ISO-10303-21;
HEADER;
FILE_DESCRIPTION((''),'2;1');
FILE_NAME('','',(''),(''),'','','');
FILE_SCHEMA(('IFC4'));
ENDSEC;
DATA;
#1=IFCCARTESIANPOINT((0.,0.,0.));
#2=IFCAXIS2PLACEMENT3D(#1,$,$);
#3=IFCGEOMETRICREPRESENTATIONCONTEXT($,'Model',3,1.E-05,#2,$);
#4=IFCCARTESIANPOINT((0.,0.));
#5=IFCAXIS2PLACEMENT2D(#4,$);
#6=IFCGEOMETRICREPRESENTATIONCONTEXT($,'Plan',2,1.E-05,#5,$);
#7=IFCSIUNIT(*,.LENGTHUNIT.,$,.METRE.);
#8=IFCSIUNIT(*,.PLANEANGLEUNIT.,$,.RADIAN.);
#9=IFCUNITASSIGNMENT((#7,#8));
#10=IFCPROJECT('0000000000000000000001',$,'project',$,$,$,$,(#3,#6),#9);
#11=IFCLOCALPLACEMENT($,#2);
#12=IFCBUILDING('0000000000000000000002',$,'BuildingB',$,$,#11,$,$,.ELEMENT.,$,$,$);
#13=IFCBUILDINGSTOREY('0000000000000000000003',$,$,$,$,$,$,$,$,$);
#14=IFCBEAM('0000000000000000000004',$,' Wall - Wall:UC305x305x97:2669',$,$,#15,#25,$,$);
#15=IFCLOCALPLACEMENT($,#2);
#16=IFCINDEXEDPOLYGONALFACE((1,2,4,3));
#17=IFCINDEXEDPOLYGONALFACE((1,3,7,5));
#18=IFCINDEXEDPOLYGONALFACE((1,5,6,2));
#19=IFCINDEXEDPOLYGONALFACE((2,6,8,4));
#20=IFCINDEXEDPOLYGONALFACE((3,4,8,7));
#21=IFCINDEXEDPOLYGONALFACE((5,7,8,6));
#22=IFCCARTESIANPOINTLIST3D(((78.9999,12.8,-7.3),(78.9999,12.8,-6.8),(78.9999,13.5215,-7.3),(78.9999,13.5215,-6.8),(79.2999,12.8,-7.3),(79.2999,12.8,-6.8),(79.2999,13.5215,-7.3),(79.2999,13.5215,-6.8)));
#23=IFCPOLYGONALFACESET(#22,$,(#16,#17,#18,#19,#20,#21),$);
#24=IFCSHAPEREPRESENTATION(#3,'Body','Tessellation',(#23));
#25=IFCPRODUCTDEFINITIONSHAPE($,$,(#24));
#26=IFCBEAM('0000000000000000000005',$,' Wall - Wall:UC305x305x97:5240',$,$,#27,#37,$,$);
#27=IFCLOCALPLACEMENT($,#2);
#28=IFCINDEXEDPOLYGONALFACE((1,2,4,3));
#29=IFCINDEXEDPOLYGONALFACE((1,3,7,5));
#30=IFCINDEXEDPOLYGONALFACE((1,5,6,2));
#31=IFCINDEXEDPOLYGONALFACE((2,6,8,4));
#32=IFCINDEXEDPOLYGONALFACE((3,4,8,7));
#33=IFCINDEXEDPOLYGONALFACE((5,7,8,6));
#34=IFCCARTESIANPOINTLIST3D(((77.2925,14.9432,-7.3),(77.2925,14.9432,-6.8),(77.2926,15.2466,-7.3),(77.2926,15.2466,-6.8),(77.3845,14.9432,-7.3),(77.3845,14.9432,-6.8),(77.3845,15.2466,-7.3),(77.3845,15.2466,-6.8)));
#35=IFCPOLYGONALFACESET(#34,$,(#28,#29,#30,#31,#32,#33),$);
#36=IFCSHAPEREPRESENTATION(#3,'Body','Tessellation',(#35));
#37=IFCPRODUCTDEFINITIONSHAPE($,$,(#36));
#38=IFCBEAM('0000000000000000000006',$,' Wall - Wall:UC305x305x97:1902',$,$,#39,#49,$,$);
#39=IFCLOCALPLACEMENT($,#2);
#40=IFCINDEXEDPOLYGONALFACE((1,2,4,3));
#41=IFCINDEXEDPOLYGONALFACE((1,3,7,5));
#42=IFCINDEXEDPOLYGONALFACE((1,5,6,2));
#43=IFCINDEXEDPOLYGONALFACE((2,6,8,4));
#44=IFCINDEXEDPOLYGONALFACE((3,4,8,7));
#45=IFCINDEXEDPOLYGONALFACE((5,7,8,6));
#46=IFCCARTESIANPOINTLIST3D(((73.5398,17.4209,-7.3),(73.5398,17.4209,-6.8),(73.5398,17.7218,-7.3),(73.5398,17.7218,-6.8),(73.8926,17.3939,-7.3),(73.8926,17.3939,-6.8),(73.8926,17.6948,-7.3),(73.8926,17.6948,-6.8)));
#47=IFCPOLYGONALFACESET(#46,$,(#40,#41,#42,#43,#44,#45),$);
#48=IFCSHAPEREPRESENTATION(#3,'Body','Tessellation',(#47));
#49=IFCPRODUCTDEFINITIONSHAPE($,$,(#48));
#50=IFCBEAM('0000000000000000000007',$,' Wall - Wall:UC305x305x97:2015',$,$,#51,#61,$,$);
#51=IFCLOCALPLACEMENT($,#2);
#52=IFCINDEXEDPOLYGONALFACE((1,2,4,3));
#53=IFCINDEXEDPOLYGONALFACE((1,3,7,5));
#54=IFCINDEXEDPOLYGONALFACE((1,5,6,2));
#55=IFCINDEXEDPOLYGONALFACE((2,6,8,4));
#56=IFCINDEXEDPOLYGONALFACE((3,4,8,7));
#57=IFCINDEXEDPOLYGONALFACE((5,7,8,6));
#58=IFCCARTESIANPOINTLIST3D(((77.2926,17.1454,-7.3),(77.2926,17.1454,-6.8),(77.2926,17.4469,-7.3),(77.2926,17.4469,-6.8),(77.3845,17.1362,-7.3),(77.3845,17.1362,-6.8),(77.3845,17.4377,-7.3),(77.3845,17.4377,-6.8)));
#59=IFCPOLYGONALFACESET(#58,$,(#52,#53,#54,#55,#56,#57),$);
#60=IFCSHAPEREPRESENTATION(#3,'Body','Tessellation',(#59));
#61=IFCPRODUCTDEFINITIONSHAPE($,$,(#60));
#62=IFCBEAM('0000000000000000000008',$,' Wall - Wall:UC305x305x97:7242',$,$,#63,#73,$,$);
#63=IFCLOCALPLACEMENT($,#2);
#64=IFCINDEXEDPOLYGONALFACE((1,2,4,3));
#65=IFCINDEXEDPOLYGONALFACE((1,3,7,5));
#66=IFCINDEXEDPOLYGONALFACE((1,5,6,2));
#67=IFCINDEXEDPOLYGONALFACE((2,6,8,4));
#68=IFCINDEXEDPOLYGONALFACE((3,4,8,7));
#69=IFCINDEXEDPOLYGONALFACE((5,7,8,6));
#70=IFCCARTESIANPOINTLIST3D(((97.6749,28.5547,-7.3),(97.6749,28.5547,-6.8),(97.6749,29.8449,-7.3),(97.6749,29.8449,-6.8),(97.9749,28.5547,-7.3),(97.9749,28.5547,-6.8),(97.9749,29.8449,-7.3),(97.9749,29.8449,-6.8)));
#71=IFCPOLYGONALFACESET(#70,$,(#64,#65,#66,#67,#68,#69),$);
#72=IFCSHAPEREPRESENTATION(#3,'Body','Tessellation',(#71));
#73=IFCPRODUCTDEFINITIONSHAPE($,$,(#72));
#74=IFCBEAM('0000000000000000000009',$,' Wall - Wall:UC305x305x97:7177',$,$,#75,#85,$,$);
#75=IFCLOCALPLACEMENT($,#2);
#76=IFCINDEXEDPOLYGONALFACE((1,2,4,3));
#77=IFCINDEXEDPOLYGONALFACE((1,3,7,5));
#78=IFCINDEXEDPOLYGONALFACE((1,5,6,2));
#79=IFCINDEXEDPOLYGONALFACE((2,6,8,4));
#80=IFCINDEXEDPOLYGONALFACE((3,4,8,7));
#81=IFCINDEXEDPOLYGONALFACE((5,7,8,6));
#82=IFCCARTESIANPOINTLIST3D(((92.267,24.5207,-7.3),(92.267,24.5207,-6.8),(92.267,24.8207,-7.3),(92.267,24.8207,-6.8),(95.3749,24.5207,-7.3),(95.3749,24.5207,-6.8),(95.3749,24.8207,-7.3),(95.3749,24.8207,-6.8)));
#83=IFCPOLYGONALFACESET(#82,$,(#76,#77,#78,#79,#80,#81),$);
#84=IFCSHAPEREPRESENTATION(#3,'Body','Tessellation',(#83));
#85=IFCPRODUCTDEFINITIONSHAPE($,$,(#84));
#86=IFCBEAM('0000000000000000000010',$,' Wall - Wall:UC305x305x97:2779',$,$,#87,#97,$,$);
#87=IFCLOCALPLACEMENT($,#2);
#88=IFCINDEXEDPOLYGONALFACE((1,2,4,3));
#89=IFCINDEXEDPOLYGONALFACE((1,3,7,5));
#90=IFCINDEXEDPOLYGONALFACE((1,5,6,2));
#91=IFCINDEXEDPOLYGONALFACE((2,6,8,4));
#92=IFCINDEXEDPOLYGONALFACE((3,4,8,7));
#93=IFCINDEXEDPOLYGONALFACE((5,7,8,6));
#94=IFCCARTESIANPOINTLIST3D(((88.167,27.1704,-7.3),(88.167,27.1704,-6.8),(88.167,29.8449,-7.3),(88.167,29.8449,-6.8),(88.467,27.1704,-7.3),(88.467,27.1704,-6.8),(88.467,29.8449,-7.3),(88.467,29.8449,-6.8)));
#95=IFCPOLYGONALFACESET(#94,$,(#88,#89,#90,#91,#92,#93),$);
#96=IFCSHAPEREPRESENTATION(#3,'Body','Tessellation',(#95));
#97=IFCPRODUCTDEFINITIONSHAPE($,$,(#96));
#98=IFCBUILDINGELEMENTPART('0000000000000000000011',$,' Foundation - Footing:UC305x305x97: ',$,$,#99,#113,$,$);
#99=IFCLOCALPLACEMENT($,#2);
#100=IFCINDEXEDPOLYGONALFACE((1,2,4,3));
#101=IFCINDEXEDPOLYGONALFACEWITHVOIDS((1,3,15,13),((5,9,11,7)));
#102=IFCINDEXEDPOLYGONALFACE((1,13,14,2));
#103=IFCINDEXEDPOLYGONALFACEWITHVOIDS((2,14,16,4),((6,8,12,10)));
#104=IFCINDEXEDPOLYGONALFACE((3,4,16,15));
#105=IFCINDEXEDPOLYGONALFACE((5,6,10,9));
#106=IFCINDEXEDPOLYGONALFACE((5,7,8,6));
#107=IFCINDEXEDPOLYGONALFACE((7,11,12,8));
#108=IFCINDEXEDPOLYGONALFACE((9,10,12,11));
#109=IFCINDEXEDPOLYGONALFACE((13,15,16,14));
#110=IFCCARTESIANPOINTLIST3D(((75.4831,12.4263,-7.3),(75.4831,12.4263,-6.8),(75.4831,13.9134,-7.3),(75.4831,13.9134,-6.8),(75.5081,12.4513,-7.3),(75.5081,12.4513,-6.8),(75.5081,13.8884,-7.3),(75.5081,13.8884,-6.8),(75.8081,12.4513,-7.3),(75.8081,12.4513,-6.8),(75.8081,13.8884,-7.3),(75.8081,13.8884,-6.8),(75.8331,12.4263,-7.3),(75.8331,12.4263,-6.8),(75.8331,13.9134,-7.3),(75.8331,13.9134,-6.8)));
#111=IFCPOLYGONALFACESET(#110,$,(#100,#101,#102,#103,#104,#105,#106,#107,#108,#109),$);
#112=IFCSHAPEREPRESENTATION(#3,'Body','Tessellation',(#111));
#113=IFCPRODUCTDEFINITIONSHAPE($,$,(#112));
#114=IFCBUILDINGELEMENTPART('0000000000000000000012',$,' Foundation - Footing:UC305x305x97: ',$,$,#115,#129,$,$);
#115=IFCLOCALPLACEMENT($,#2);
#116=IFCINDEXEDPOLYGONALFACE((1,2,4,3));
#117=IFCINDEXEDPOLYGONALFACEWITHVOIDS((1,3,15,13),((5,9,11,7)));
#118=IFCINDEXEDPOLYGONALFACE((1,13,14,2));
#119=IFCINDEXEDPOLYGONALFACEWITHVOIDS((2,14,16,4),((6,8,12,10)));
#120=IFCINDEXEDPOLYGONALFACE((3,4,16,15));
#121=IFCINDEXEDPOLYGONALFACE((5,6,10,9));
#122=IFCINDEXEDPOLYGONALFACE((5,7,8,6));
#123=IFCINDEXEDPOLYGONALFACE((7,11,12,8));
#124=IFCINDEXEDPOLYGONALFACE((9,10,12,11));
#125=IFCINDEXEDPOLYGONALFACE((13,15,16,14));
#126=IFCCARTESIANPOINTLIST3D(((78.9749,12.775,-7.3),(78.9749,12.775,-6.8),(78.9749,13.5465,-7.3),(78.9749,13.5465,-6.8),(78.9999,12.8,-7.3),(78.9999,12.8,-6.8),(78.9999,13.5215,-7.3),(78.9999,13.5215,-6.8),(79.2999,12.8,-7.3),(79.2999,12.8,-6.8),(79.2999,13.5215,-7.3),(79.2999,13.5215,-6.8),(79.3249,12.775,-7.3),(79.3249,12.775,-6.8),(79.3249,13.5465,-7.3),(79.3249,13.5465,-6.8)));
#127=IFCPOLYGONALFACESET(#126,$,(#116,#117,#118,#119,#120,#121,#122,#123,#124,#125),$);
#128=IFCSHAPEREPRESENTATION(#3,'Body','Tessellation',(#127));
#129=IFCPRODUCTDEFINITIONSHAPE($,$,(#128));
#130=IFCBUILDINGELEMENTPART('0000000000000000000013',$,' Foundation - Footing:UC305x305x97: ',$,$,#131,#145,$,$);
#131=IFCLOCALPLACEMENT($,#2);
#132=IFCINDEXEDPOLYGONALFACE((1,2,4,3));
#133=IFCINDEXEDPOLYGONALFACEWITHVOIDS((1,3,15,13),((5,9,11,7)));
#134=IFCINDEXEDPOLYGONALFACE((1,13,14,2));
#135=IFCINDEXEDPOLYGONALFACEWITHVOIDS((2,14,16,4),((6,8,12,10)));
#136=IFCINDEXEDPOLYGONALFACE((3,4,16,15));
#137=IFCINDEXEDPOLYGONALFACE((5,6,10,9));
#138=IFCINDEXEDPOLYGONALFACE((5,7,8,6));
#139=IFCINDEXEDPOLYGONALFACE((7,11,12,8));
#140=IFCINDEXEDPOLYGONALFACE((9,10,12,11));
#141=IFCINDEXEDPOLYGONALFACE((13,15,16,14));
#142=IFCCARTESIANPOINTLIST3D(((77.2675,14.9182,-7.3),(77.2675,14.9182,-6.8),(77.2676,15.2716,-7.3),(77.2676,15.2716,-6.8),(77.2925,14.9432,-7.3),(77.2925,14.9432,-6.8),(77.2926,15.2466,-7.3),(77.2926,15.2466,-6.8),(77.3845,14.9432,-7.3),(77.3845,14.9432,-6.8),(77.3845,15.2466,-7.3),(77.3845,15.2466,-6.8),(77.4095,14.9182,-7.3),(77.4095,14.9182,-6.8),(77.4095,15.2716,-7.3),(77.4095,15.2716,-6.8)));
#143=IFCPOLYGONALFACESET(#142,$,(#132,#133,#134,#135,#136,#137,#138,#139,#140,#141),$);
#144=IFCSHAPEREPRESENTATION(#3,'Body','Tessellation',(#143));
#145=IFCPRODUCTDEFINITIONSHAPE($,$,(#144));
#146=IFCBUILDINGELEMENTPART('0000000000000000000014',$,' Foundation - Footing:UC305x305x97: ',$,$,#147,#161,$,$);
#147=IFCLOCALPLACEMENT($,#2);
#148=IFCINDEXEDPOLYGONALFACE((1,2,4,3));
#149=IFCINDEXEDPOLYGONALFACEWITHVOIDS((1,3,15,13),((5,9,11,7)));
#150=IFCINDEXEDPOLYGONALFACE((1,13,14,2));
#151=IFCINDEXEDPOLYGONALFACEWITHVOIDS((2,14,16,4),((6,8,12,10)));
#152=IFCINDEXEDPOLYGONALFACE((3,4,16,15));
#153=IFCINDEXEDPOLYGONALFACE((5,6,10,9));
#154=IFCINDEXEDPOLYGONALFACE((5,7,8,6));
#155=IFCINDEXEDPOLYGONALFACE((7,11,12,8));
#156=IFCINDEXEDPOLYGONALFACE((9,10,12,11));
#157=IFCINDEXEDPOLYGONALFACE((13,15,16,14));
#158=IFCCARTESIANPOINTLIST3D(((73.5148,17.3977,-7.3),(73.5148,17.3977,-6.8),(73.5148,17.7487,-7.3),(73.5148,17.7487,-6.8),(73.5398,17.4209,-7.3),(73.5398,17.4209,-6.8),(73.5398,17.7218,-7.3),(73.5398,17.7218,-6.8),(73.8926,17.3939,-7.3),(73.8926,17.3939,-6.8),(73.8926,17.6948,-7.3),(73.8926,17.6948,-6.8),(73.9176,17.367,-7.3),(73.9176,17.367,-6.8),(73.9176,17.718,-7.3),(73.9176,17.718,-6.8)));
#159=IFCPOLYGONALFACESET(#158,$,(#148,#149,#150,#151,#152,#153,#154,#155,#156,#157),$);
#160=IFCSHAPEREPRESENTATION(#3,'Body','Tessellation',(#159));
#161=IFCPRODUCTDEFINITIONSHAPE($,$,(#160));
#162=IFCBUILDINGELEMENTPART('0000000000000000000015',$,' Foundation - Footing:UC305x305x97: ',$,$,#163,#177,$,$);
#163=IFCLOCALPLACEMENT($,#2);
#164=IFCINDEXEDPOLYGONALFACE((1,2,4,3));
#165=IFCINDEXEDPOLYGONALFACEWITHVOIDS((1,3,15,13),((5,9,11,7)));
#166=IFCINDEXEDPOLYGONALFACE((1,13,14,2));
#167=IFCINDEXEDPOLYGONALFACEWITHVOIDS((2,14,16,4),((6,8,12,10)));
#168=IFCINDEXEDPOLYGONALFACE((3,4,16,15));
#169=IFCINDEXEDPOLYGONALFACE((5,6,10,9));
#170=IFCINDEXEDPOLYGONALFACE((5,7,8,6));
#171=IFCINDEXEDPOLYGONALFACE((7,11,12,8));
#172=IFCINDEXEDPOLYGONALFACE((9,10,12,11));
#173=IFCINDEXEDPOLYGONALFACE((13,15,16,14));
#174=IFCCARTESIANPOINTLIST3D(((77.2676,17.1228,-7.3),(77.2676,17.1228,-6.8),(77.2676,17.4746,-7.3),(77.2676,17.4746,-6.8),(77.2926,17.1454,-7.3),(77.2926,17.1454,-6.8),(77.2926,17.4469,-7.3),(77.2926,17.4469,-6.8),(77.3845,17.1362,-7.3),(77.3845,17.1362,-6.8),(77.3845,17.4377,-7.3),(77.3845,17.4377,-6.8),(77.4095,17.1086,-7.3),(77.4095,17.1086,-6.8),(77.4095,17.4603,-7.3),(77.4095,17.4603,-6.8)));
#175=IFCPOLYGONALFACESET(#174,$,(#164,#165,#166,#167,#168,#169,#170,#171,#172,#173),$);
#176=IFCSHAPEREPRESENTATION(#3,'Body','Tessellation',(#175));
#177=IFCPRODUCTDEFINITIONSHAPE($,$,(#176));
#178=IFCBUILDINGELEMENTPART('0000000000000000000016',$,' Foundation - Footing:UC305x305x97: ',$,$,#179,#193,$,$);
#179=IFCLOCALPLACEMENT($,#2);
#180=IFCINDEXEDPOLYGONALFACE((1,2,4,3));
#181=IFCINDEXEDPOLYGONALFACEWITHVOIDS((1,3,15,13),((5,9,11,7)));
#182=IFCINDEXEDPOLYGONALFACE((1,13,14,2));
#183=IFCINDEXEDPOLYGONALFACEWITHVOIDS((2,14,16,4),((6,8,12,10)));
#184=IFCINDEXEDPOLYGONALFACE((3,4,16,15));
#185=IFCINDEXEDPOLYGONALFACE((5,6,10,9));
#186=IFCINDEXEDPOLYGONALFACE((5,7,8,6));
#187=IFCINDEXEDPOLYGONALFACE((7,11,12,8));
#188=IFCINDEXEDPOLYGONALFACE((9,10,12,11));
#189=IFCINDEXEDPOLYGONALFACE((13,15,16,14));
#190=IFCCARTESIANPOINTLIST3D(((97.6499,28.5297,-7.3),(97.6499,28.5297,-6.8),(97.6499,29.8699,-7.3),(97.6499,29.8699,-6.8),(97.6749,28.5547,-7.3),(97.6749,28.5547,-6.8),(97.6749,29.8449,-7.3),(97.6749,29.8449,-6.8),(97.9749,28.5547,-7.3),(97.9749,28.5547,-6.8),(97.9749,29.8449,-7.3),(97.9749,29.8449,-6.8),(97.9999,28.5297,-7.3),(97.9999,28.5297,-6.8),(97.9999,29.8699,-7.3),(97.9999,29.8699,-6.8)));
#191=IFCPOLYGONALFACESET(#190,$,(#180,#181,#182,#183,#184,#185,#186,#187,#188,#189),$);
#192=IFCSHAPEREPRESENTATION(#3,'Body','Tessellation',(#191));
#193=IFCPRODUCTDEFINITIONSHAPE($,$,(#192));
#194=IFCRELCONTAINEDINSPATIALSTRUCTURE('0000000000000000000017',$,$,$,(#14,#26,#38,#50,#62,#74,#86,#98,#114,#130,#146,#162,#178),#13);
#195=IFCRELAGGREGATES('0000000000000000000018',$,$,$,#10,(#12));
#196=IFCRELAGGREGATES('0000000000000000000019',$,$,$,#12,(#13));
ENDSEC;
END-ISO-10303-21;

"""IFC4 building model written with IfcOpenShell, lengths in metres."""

from ifc_helpers import new_model, si_unit, origin, origin_2d, place, context, project, spatial, polyline, outline, extrude, element, save


model = new_model("IFC4")

# Units and contexts
model_context = context("Model", 3, precision=1e-05, world=origin())
plan_context = context("Plan", 2, precision=1e-05, world=origin_2d())
ifc_project = project(units=[si_unit("LENGTHUNIT", "METRE"), si_unit("PLANEANGLEUNIT", "RADIAN")], contexts=[model_context, plan_context])

# Building, storey
building_placement = place(None, origin())
building = spatial("IfcBuilding", under=ifc_project, at=building_placement, Name="BuildingB", CompositionType="ELEMENT")
storey = spatial("IfcBuildingStorey", under=building)

# Beams
element("IfcBeam", 1, inside=storey, Name=" Wall - Wall:UC305x305x97:2669", context=model_context, shape_type="SweptSolid", body=[
    extrude(outline(polyline([(79.2999, 12.8, -7.3), (78.9999, 12.8, -7.3), (78.9999, 13.5215, -7.3), (79.2999, 13.5215, -7.3), (79.2999, 12.8, -7.3)])), None, (0.0, 0.0, 1.0), 0.5),
])
element("IfcBeam", 2, inside=storey, Name=" Wall - Wall:UC305x305x97:5240", context=model_context, shape_type="SweptSolid", body=[
    extrude(outline(polyline([(77.3845, 14.9432, -7.3), (77.2925, 14.9432, -7.3), (77.2926, 15.2466, -7.3), (77.3845, 15.2466, -7.3), (77.3845, 14.9432, -7.3)])), None, (0.0, 0.0, 1.0), 0.5),
])
element("IfcBeam", 3, inside=storey, Name=" Wall - Wall:UC305x305x97:1902", context=model_context, shape_type="SweptSolid", body=[
    extrude(outline(polyline([(73.8926, 17.3939, -7.3), (73.5398, 17.4209, -7.3), (73.5398, 17.7218, -7.3), (73.8926, 17.6948, -7.3), (73.8926, 17.3939, -7.3)])), None, (0.0, 0.0, 1.0), 0.5),
])
element("IfcBeam", 4, inside=storey, Name=" Wall - Wall:UC305x305x97:2015", context=model_context, shape_type="SweptSolid", body=[
    extrude(outline(polyline([(77.3845, 17.1362, -7.3), (77.2926, 17.1454, -7.3), (77.2926, 17.4469, -7.3), (77.3845, 17.4377, -7.3), (77.3845, 17.1362, -7.3)])), None, (0.0, 0.0, 1.0), 0.5),
])
element("IfcBeam", 5, inside=storey, Name=" Wall - Wall:UC305x305x97:7242", context=model_context, shape_type="SweptSolid", body=[
    extrude(outline(polyline([(97.9749, 28.5547, -7.3), (97.6749, 28.5547, -7.3), (97.6749, 29.8449, -7.3), (97.9749, 29.8449, -7.3), (97.9749, 28.5547, -7.3)])), None, (0.0, 0.0, 1.0), 0.5),
])
element("IfcBeam", 6, inside=storey, Name=" Wall - Wall:UC305x305x97:7177", context=model_context, shape_type="SweptSolid", body=[
    extrude(outline(polyline([(95.3749, 24.5207, -7.3), (95.3749, 24.8207, -7.3), (92.267, 24.8207, -7.3), (92.267, 24.5207, -7.3), (95.3749, 24.5207, -7.3)])), None, (0.0, 0.0, 1.0), 0.5),
])
element("IfcBeam", 7, inside=storey, Name=" Wall - Wall:UC305x305x97:2779", context=model_context, shape_type="SweptSolid", body=[
    extrude(outline(polyline([(88.467, 27.1704, -7.3), (88.167, 27.1704, -7.3), (88.167, 29.8449, -7.3), (88.467, 29.8449, -7.3), (88.467, 27.1704, -7.3)])), None, (0.0, 0.0, 1.0), 0.5),
])

# Building element parts, openings
building_element_part_1 = element("IfcBuildingElementPart", 8, inside=storey, Name=" Foundation - Footing:UC305x305x97: ", context=model_context, shape_type="SweptSolid", body=[
    extrude(outline(polyline([(75.8331, 12.4263, -7.3), (75.4831, 12.4263, -7.3), (75.4831, 13.9134, -7.3), (75.8331, 13.9134, -7.3), (75.8331, 12.4263, -7.3)])), None, (0.0, 0.0, 1.0), 0.5),
])
element("IfcOpeningElement", 9, inside=storey, cuts=building_element_part_1, context=model_context, shape_type="SweptSolid", body=[
    extrude(outline(polyline([(75.8081, 12.4513, -7.3), (75.5081, 12.4513, -7.3), (75.5081, 13.8884, -7.3), (75.8081, 13.8884, -7.3), (75.8081, 12.4513, -7.3)])), None, (0.0, 0.0, 1.0), 0.5),
])
building_element_part_2 = element("IfcBuildingElementPart", 10, inside=storey, Name=" Foundation - Footing:UC305x305x97: ", context=model_context, shape_type="SweptSolid", body=[
    extrude(outline(polyline([(79.3249, 12.775, -7.3), (78.9749, 12.775, -7.3), (78.9749, 13.5465, -7.3), (79.3249, 13.5465, -7.3), (79.3249, 12.775, -7.3)])), None, (0.0, 0.0, 1.0), 0.5),
])
element("IfcOpeningElement", 11, inside=storey, cuts=building_element_part_2, context=model_context, shape_type="SweptSolid", body=[
    extrude(outline(polyline([(79.2999, 12.8, -7.3), (78.9999, 12.8, -7.3), (78.9999, 13.5215, -7.3), (79.2999, 13.5215, -7.3), (79.2999, 12.8, -7.3)])), None, (0.0, 0.0, 1.0), 0.5),
])
building_element_part_3 = element("IfcBuildingElementPart", 12, inside=storey, Name=" Foundation - Footing:UC305x305x97: ", context=model_context, shape_type="SweptSolid", body=[
    extrude(outline(polyline([(77.4095, 14.9182, -7.3), (77.2675, 14.9182, -7.3), (77.2676, 15.2716, -7.3), (77.4095, 15.2716, -7.3), (77.4095, 14.9182, -7.3)])), None, (0.0, 0.0, 1.0), 0.5),
])
element("IfcOpeningElement", 13, inside=storey, cuts=building_element_part_3, context=model_context, shape_type="SweptSolid", body=[
    extrude(outline(polyline([(77.3845, 14.9432, -7.3), (77.2925, 14.9432, -7.3), (77.2926, 15.2466, -7.3), (77.3845, 15.2466, -7.3), (77.3845, 14.9432, -7.3)])), None, (0.0, 0.0, 1.0), 0.5),
])
building_element_part_4 = element("IfcBuildingElementPart", 14, inside=storey, Name=" Foundation - Footing:UC305x305x97: ", context=model_context, shape_type="SweptSolid", body=[
    extrude(outline(polyline([(73.9176, 17.367, -7.3), (73.5148, 17.3977, -7.3), (73.5148, 17.7487, -7.3), (73.9176, 17.718, -7.3), (73.9176, 17.367, -7.3)])), None, (0.0, 0.0, 1.0), 0.5),
])
element("IfcOpeningElement", 15, inside=storey, cuts=building_element_part_4, context=model_context, shape_type="SweptSolid", body=[
    extrude(outline(polyline([(73.8926, 17.3939, -7.3), (73.5398, 17.4209, -7.3), (73.5398, 17.7218, -7.3), (73.8926, 17.6948, -7.3), (73.8926, 17.3939, -7.3)])), None, (0.0, 0.0, 1.0), 0.5),
])
building_element_part_5 = element("IfcBuildingElementPart", 16, inside=storey, Name=" Foundation - Footing:UC305x305x97: ", context=model_context, shape_type="SweptSolid", body=[
    extrude(outline(polyline([(77.4095, 17.1086, -7.3), (77.2676, 17.1228, -7.3), (77.2676, 17.4746, -7.3), (77.4095, 17.4603, -7.3), (77.4095, 17.1086, -7.3)])), None, (0.0, 0.0, 1.0), 0.5),
])
element("IfcOpeningElement", 17, inside=storey, cuts=building_element_part_5, context=model_context, shape_type="SweptSolid", body=[
    extrude(outline(polyline([(77.3845, 17.1362, -7.3), (77.2926, 17.1454, -7.3), (77.2926, 17.4469, -7.3), (77.3845, 17.4377, -7.3), (77.3845, 17.1362, -7.3)])), None, (0.0, 0.0, 1.0), 0.5),
])
building_element_part_6 = element("IfcBuildingElementPart", 18, inside=storey, Name=" Foundation - Footing:UC305x305x97: ", context=model_context, shape_type="SweptSolid", body=[
    extrude(outline(polyline([(97.9999, 28.5297, -7.3), (97.6499, 28.5297, -7.3), (97.6499, 29.8699, -7.3), (97.9999, 29.8699, -7.3), (97.9999, 28.5297, -7.3)])), None, (0.0, 0.0, 1.0), 0.5),
])
element("IfcOpeningElement", 19, inside=storey, cuts=building_element_part_6, context=model_context, shape_type="SweptSolid", body=[
    extrude(outline(polyline([(97.9749, 28.5547, -7.3), (97.6749, 28.5547, -7.3), (97.6749, 29.8449, -7.3), (97.9749, 29.8449, -7.3), (97.9749, 28.5547, -7.3)])), None, (0.0, 0.0, 1.0), 0.5),
])

save(model, "model.ifc")
